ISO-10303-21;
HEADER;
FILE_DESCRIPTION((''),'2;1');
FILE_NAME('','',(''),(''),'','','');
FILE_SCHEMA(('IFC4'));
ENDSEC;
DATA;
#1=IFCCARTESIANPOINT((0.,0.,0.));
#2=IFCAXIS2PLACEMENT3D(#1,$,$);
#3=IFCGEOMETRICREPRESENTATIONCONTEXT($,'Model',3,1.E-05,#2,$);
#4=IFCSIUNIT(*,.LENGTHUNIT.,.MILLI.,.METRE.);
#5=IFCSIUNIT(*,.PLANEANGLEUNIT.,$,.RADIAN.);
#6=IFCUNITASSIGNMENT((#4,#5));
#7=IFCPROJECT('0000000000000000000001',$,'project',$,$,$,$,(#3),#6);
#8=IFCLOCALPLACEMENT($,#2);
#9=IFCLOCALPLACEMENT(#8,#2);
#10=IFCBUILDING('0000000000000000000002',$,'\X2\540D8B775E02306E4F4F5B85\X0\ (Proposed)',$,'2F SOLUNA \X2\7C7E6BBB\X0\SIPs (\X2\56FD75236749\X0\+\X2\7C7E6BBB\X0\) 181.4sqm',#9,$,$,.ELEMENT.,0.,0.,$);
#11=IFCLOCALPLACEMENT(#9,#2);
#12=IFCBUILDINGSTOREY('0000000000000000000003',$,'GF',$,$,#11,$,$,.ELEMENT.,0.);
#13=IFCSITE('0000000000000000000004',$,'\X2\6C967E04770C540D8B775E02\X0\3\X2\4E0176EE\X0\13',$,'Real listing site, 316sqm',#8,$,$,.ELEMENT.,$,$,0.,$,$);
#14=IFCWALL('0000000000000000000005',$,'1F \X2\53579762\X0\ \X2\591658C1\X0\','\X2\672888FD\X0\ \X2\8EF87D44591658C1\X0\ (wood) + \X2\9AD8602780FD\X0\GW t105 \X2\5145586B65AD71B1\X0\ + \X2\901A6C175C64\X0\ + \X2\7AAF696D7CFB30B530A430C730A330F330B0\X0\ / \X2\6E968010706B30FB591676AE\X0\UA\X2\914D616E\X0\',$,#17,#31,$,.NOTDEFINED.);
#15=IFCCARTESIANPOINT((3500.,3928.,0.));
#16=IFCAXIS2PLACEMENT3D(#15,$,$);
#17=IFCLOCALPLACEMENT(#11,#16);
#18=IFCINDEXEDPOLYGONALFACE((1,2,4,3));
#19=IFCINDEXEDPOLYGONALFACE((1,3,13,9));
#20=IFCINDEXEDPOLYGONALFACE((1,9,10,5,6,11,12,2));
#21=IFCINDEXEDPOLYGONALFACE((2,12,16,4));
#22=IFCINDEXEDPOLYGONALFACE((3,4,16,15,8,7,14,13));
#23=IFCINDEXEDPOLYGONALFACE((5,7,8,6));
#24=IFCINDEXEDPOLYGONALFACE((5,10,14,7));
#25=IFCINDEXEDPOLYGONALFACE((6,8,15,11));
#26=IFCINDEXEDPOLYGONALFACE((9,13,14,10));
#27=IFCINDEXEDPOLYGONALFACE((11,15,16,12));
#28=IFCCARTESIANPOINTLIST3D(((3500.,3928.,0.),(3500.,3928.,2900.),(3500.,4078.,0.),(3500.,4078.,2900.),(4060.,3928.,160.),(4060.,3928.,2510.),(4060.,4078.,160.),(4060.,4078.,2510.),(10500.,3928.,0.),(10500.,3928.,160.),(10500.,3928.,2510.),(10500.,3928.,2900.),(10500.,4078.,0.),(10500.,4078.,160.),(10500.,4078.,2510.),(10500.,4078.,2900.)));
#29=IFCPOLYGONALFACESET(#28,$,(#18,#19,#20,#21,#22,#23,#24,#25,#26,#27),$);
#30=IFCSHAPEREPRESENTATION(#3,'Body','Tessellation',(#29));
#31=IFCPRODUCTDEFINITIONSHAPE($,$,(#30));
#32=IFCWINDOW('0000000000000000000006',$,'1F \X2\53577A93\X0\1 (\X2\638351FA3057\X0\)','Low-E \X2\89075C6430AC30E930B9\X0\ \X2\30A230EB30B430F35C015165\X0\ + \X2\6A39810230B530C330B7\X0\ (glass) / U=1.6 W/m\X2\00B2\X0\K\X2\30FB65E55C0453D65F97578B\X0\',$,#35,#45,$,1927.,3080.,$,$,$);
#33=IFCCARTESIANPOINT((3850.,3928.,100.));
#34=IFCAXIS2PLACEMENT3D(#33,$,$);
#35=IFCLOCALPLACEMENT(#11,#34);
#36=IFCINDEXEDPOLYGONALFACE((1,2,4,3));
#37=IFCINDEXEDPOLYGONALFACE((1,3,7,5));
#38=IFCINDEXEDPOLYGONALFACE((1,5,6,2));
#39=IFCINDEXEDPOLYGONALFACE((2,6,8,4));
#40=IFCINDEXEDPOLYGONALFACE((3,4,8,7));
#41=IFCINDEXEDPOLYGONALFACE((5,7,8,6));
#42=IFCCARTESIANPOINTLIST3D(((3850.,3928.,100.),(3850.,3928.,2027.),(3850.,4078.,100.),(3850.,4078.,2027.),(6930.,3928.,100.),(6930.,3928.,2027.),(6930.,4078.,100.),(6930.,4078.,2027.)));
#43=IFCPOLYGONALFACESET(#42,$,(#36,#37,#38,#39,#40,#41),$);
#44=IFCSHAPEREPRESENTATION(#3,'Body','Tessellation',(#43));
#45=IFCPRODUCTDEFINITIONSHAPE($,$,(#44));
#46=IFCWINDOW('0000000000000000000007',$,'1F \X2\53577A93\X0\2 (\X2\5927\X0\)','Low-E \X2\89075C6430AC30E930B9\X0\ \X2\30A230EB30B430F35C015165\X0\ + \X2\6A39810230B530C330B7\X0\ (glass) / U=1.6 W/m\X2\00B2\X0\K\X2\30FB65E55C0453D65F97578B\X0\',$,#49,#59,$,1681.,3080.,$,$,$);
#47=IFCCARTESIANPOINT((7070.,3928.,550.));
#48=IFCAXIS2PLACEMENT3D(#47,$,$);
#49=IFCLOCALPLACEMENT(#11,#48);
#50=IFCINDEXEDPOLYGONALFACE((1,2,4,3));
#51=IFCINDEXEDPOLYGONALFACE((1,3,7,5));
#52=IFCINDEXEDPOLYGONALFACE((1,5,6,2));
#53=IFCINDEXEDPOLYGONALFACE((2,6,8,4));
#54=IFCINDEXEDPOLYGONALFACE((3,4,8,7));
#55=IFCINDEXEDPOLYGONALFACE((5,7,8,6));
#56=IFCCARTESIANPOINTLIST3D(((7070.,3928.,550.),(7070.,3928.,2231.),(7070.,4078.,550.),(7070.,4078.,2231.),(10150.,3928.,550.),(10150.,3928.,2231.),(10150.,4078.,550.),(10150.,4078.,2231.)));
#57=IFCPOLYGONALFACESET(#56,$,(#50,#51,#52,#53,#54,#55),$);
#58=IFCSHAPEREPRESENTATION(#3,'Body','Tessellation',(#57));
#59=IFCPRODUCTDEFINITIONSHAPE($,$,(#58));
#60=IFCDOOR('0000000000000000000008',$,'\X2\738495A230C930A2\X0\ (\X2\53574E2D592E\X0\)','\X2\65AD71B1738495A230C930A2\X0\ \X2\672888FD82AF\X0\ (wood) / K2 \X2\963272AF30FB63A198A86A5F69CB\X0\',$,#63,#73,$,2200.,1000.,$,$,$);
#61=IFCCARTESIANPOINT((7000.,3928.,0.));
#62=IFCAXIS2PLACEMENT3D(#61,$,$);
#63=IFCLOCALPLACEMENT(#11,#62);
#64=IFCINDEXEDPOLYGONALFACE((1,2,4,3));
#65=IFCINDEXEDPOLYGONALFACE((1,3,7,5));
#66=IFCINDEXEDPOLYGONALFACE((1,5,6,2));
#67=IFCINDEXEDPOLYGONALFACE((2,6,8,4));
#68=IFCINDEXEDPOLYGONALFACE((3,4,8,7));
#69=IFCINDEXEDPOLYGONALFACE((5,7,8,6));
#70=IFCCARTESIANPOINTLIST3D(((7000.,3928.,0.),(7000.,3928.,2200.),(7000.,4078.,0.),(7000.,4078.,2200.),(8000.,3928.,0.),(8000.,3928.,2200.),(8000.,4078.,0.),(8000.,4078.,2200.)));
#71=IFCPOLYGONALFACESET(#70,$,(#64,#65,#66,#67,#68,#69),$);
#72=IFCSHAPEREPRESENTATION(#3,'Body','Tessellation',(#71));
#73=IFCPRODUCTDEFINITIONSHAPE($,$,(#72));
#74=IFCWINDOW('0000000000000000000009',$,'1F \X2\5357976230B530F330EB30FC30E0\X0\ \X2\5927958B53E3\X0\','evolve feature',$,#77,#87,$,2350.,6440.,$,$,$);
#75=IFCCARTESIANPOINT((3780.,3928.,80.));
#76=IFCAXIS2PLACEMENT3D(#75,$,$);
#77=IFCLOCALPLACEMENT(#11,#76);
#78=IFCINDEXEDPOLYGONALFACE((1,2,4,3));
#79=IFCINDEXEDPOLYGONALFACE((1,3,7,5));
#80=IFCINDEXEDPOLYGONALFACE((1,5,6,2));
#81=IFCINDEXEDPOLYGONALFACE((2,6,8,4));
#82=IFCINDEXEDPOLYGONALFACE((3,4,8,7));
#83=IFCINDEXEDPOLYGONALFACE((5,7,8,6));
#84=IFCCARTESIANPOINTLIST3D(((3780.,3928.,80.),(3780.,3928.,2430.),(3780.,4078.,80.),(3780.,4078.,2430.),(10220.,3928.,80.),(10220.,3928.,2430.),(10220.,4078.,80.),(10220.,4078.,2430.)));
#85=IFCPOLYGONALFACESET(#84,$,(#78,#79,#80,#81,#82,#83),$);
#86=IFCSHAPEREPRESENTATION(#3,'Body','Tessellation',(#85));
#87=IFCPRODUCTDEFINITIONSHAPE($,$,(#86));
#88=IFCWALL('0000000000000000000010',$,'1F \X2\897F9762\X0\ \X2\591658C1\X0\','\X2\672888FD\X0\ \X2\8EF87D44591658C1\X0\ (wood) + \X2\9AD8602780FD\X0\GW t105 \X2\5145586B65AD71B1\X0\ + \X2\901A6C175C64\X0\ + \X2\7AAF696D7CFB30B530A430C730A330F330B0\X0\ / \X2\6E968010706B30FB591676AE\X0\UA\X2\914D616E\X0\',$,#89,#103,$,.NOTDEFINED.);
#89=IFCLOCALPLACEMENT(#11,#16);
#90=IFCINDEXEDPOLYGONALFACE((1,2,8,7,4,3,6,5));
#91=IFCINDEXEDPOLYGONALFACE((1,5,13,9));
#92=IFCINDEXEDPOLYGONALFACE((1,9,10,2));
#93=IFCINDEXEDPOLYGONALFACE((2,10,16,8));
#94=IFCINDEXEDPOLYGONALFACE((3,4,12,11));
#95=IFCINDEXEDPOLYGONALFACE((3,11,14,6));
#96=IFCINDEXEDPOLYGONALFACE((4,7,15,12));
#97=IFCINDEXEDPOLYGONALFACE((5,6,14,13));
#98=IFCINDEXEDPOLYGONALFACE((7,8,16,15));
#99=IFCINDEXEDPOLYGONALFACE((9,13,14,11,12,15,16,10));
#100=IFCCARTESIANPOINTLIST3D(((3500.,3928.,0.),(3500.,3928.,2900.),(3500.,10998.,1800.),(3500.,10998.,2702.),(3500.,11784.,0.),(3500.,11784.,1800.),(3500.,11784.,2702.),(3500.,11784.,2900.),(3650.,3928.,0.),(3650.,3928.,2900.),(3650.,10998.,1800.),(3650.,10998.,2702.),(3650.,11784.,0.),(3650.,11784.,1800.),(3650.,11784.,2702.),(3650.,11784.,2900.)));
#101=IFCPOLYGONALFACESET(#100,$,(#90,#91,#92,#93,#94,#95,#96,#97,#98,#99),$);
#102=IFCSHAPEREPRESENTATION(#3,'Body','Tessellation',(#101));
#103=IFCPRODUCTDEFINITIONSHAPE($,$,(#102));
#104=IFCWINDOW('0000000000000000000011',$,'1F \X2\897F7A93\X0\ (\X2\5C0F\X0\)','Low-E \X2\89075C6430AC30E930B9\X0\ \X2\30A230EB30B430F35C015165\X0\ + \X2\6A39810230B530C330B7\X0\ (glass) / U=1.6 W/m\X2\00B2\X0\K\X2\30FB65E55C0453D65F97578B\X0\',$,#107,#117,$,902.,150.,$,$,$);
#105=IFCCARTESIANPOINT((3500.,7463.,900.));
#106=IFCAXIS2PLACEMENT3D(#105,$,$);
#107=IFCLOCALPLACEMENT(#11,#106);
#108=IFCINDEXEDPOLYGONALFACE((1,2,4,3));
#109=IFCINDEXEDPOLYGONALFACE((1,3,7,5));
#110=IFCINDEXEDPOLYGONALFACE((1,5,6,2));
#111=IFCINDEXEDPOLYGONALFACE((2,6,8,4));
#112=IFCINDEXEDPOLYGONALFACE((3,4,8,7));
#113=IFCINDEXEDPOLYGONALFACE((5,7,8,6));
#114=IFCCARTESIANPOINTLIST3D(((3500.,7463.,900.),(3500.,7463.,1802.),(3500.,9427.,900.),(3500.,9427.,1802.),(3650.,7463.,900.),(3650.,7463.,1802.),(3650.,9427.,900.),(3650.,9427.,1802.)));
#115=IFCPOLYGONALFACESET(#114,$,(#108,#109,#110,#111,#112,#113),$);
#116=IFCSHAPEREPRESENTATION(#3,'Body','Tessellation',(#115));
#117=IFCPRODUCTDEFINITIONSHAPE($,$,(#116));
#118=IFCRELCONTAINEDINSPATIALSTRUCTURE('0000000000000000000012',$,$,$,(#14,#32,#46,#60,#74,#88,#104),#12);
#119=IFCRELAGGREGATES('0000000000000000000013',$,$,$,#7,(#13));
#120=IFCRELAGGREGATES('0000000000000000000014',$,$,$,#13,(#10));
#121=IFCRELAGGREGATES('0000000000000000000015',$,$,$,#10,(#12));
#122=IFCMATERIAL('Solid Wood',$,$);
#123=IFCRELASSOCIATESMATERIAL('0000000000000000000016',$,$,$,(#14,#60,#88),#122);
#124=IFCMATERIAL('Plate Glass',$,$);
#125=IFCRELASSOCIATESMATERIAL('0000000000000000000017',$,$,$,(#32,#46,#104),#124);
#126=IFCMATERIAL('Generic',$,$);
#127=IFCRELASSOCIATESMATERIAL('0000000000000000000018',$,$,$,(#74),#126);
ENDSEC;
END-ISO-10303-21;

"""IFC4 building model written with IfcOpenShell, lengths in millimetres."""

from ifc_helpers import new_model, si_unit, frame, frame_2d, origin, place, context, project, spatial, rectangle, extrude, material, element, fill, save


model = new_model("IFC4")

# Units and contexts
model_context = context("Model", 3, precision=1e-05, world=origin())
ifc_project = project(units=[si_unit("LENGTHUNIT", "METRE", prefix="MILLI"), si_unit("PLANEANGLEUNIT", "RADIAN")], contexts=[model_context])

# Site, building, storey
site_placement = place(None, origin())
site = spatial("IfcSite", under=ifc_project, at=site_placement, Name="沖縄県名護市3丁目13", ObjectType="Real listing site, 316sqm", CompositionType="ELEMENT", RefElevation=0.0)
building_placement = place(site_placement, origin())
building = spatial("IfcBuilding", under=site, at=building_placement, Name="名護市の住宅 (Proposed)", ObjectType="2F SOLUNA 籾殻SIPs (国産杉+籾殻) 181.4sqm", CompositionType="ELEMENT", ElevationOfRefHeight=0.0, ElevationOfTerrain=0.0)
storey_placement = place(building_placement, origin())
storey = spatial("IfcBuildingStorey", under=building, at=storey_placement, Name="GF", CompositionType="ELEMENT", Elevation=0.0)

# Shared definitions
ifc_material_1 = material(Name="Solid Wood")
ifc_material_2 = material(Name="Generic")

# Wall, openings, windows, door
wall_1_placement = place(storey_placement, frame((3500.0, 3928.0, 0.0)))
wall_1 = element("IfcWall", 1, at=wall_1_placement, inside=storey, material=ifc_material_1, Name="1F 南面 外壁", Description="木製 軸組外壁 (wood) + 高性能GW t105 充填断熱 + 通気層 + 窯業系サイディング / 準耐火・外皮UA配慮", PredefinedType="NOTDEFINED", context=model_context, shape_type="SweptSolid", body=[
    extrude(rectangle(XDim=7000.0, YDim=150.0, at=frame_2d((3500.0, 75.0))), frame((3500.0, 3928.0, 0.0)), (0.0, 0.0, 1.0), 2900.0),
])
opening_1_placement = place(storey_placement, frame((3850.0, 3928.0, 100.0)))
opening_1 = element("IfcOpeningElement", 2, at=opening_1_placement, cuts=wall_1, PredefinedType="NOTDEFINED", context=model_context, shape_type="SweptSolid", body=[
    extrude(rectangle(XDim=3080.0, YDim=150.0, at=frame_2d((1540.0, 75.0))), frame((3850.0, 3928.0, 100.0)), (0.0, 0.0, 1.0), 1927.0),
])
opening_2_placement = place(storey_placement, frame((7070.0, 3928.0, 550.0)))
opening_2 = element("IfcOpeningElement", 3, at=opening_2_placement, cuts=wall_1, PredefinedType="NOTDEFINED", context=model_context, shape_type="SweptSolid", body=[
    extrude(rectangle(XDim=3080.0, YDim=150.0, at=frame_2d((1540.0, 75.0))), frame((7070.0, 3928.0, 550.0)), (0.0, 0.0, 1.0), 1681.0),
])
opening_3_placement = place(storey_placement, frame((7000.0, 3928.0, 0.0)))
opening_3 = element("IfcOpeningElement", 4, at=opening_3_placement, cuts=wall_1, PredefinedType="NOTDEFINED", context=model_context, shape_type="SweptSolid", body=[
    extrude(rectangle(XDim=1000.0, YDim=150.0, at=frame_2d((500.0, 75.0))), frame((7000.0, 3928.0, 0.0)), (0.0, 0.0, 1.0), 2200.0),
])
opening_4_placement = place(storey_placement, frame((3780.0, 3928.0, 80.0)))
opening_4 = element("IfcOpeningElement", 5, at=opening_4_placement, cuts=wall_1, PredefinedType="NOTDEFINED", context=model_context, shape_type="SweptSolid", body=[
    extrude(rectangle(XDim=6440.0, YDim=150.0, at=frame_2d((3220.0, 75.0))), frame((3780.0, 3928.0, 80.0)), (0.0, 0.0, 1.0), 2350.0),
])
ifc_material_3 = material(Name="Plate Glass")
window_1_placement = place(storey_placement, frame((3850.0, 3928.0, 100.0)))
window_1 = element("IfcWindow", 6, at=window_1_placement, inside=storey, material=ifc_material_3, Name="1F 南窓1 (掃出し)", Description="Low-E 複層ガラス アルゴン封入 + 樹脂サッシ (glass) / U=1.6 W/m²K・日射取得型", OverallHeight=1927.0, OverallWidth=3080.0, context=model_context, shape_type="SweptSolid", body=[
    extrude(rectangle(XDim=3080.0, YDim=150.0, at=frame_2d((1540.0, 75.0))), frame((3850.0, 3928.0, 100.0)), (0.0, 0.0, 1.0), 1927.0),
])
fill(opening_1, window_1)
window_2_placement = place(storey_placement, frame((7070.0, 3928.0, 550.0)))
window_2 = element("IfcWindow", 7, at=window_2_placement, inside=storey, material=ifc_material_3, Name="1F 南窓2 (大)", Description="Low-E 複層ガラス アルゴン封入 + 樹脂サッシ (glass) / U=1.6 W/m²K・日射取得型", OverallHeight=1681.0, OverallWidth=3080.0, context=model_context, shape_type="SweptSolid", body=[
    extrude(rectangle(XDim=3080.0, YDim=150.0, at=frame_2d((1540.0, 75.0))), frame((7070.0, 3928.0, 550.0)), (0.0, 0.0, 1.0), 1681.0),
])
fill(opening_2, window_2)
door_placement = place(storey_placement, frame((7000.0, 3928.0, 0.0)))
door = element("IfcDoor", 8, at=door_placement, inside=storey, material=ifc_material_1, Name="玄関ドア (南中央)", Description="断熱玄関ドア 木製芯 (wood) / K2 防犯・採風機構", OverallHeight=2200.0, OverallWidth=1000.0, context=model_context, shape_type="SweptSolid", body=[
    extrude(rectangle(XDim=1000.0, YDim=150.0, at=frame_2d((500.0, 75.0))), frame((7000.0, 3928.0, 0.0)), (0.0, 0.0, 1.0), 2200.0),
])
fill(opening_3, door)
window_3_placement = place(storey_placement, frame((3780.0, 3928.0, 80.0)))
window_3 = element("IfcWindow", 9, at=window_3_placement, inside=storey, material=ifc_material_2, Name="1F 南面サンルーム 大開口", Description="evolve feature", OverallHeight=2350.0, OverallWidth=6440.0, context=model_context, shape_type="SweptSolid", body=[
    extrude(rectangle(XDim=6440.0, YDim=150.0, at=frame_2d((3220.0, 75.0))), frame((3780.0, 3928.0, 80.0)), (0.0, 0.0, 1.0), 2350.0),
])
fill(opening_4, window_3)

# Wall, opening, window
wall_2_placement = place(storey_placement, frame((3500.0, 3928.0, 0.0)))
wall_2 = element("IfcWall", 10, at=wall_2_placement, inside=storey, material=ifc_material_1, Name="1F 西面 外壁", Description="木製 軸組外壁 (wood) + 高性能GW t105 充填断熱 + 通気層 + 窯業系サイディング / 準耐火・外皮UA配慮", PredefinedType="NOTDEFINED", context=model_context, shape_type="SweptSolid", body=[
    extrude(rectangle(XDim=150.0, YDim=7856.0, at=frame_2d((75.0, 3928.0))), frame((3500.0, 3928.0, 0.0)), (0.0, 0.0, 1.0), 2900.0),
])
opening_5_placement = place(storey_placement, frame((3500.0, 7463.0, 900.0)))
opening_5 = element("IfcOpeningElement", 11, at=opening_5_placement, cuts=wall_2, PredefinedType="NOTDEFINED", context=model_context, shape_type="SweptSolid", body=[
    extrude(rectangle(XDim=150.0, YDim=1964.0, at=frame_2d((75.0, 982.0))), frame((3500.0, 7463.0, 900.0)), (0.0, 0.0, 1.0), 902.0),
])
window_4_placement = place(storey_placement, frame((3500.0, 7463.0, 900.0)))
window_4 = element("IfcWindow", 12, at=window_4_placement, inside=storey, material=ifc_material_3, Name="1F 西窓 (小)", Description="Low-E 複層ガラス アルゴン封入 + 樹脂サッシ (glass) / U=1.6 W/m²K・日射取得型", OverallHeight=902.0, OverallWidth=150.0, context=model_context, shape_type="SweptSolid", body=[
    extrude(rectangle(XDim=150.0, YDim=1964.0, at=frame_2d((75.0, 982.0))), frame((3500.0, 7463.0, 900.0)), (0.0, 0.0, 1.0), 902.0),
])
fill(opening_5, window_4)

save(model, "model.ifc")
